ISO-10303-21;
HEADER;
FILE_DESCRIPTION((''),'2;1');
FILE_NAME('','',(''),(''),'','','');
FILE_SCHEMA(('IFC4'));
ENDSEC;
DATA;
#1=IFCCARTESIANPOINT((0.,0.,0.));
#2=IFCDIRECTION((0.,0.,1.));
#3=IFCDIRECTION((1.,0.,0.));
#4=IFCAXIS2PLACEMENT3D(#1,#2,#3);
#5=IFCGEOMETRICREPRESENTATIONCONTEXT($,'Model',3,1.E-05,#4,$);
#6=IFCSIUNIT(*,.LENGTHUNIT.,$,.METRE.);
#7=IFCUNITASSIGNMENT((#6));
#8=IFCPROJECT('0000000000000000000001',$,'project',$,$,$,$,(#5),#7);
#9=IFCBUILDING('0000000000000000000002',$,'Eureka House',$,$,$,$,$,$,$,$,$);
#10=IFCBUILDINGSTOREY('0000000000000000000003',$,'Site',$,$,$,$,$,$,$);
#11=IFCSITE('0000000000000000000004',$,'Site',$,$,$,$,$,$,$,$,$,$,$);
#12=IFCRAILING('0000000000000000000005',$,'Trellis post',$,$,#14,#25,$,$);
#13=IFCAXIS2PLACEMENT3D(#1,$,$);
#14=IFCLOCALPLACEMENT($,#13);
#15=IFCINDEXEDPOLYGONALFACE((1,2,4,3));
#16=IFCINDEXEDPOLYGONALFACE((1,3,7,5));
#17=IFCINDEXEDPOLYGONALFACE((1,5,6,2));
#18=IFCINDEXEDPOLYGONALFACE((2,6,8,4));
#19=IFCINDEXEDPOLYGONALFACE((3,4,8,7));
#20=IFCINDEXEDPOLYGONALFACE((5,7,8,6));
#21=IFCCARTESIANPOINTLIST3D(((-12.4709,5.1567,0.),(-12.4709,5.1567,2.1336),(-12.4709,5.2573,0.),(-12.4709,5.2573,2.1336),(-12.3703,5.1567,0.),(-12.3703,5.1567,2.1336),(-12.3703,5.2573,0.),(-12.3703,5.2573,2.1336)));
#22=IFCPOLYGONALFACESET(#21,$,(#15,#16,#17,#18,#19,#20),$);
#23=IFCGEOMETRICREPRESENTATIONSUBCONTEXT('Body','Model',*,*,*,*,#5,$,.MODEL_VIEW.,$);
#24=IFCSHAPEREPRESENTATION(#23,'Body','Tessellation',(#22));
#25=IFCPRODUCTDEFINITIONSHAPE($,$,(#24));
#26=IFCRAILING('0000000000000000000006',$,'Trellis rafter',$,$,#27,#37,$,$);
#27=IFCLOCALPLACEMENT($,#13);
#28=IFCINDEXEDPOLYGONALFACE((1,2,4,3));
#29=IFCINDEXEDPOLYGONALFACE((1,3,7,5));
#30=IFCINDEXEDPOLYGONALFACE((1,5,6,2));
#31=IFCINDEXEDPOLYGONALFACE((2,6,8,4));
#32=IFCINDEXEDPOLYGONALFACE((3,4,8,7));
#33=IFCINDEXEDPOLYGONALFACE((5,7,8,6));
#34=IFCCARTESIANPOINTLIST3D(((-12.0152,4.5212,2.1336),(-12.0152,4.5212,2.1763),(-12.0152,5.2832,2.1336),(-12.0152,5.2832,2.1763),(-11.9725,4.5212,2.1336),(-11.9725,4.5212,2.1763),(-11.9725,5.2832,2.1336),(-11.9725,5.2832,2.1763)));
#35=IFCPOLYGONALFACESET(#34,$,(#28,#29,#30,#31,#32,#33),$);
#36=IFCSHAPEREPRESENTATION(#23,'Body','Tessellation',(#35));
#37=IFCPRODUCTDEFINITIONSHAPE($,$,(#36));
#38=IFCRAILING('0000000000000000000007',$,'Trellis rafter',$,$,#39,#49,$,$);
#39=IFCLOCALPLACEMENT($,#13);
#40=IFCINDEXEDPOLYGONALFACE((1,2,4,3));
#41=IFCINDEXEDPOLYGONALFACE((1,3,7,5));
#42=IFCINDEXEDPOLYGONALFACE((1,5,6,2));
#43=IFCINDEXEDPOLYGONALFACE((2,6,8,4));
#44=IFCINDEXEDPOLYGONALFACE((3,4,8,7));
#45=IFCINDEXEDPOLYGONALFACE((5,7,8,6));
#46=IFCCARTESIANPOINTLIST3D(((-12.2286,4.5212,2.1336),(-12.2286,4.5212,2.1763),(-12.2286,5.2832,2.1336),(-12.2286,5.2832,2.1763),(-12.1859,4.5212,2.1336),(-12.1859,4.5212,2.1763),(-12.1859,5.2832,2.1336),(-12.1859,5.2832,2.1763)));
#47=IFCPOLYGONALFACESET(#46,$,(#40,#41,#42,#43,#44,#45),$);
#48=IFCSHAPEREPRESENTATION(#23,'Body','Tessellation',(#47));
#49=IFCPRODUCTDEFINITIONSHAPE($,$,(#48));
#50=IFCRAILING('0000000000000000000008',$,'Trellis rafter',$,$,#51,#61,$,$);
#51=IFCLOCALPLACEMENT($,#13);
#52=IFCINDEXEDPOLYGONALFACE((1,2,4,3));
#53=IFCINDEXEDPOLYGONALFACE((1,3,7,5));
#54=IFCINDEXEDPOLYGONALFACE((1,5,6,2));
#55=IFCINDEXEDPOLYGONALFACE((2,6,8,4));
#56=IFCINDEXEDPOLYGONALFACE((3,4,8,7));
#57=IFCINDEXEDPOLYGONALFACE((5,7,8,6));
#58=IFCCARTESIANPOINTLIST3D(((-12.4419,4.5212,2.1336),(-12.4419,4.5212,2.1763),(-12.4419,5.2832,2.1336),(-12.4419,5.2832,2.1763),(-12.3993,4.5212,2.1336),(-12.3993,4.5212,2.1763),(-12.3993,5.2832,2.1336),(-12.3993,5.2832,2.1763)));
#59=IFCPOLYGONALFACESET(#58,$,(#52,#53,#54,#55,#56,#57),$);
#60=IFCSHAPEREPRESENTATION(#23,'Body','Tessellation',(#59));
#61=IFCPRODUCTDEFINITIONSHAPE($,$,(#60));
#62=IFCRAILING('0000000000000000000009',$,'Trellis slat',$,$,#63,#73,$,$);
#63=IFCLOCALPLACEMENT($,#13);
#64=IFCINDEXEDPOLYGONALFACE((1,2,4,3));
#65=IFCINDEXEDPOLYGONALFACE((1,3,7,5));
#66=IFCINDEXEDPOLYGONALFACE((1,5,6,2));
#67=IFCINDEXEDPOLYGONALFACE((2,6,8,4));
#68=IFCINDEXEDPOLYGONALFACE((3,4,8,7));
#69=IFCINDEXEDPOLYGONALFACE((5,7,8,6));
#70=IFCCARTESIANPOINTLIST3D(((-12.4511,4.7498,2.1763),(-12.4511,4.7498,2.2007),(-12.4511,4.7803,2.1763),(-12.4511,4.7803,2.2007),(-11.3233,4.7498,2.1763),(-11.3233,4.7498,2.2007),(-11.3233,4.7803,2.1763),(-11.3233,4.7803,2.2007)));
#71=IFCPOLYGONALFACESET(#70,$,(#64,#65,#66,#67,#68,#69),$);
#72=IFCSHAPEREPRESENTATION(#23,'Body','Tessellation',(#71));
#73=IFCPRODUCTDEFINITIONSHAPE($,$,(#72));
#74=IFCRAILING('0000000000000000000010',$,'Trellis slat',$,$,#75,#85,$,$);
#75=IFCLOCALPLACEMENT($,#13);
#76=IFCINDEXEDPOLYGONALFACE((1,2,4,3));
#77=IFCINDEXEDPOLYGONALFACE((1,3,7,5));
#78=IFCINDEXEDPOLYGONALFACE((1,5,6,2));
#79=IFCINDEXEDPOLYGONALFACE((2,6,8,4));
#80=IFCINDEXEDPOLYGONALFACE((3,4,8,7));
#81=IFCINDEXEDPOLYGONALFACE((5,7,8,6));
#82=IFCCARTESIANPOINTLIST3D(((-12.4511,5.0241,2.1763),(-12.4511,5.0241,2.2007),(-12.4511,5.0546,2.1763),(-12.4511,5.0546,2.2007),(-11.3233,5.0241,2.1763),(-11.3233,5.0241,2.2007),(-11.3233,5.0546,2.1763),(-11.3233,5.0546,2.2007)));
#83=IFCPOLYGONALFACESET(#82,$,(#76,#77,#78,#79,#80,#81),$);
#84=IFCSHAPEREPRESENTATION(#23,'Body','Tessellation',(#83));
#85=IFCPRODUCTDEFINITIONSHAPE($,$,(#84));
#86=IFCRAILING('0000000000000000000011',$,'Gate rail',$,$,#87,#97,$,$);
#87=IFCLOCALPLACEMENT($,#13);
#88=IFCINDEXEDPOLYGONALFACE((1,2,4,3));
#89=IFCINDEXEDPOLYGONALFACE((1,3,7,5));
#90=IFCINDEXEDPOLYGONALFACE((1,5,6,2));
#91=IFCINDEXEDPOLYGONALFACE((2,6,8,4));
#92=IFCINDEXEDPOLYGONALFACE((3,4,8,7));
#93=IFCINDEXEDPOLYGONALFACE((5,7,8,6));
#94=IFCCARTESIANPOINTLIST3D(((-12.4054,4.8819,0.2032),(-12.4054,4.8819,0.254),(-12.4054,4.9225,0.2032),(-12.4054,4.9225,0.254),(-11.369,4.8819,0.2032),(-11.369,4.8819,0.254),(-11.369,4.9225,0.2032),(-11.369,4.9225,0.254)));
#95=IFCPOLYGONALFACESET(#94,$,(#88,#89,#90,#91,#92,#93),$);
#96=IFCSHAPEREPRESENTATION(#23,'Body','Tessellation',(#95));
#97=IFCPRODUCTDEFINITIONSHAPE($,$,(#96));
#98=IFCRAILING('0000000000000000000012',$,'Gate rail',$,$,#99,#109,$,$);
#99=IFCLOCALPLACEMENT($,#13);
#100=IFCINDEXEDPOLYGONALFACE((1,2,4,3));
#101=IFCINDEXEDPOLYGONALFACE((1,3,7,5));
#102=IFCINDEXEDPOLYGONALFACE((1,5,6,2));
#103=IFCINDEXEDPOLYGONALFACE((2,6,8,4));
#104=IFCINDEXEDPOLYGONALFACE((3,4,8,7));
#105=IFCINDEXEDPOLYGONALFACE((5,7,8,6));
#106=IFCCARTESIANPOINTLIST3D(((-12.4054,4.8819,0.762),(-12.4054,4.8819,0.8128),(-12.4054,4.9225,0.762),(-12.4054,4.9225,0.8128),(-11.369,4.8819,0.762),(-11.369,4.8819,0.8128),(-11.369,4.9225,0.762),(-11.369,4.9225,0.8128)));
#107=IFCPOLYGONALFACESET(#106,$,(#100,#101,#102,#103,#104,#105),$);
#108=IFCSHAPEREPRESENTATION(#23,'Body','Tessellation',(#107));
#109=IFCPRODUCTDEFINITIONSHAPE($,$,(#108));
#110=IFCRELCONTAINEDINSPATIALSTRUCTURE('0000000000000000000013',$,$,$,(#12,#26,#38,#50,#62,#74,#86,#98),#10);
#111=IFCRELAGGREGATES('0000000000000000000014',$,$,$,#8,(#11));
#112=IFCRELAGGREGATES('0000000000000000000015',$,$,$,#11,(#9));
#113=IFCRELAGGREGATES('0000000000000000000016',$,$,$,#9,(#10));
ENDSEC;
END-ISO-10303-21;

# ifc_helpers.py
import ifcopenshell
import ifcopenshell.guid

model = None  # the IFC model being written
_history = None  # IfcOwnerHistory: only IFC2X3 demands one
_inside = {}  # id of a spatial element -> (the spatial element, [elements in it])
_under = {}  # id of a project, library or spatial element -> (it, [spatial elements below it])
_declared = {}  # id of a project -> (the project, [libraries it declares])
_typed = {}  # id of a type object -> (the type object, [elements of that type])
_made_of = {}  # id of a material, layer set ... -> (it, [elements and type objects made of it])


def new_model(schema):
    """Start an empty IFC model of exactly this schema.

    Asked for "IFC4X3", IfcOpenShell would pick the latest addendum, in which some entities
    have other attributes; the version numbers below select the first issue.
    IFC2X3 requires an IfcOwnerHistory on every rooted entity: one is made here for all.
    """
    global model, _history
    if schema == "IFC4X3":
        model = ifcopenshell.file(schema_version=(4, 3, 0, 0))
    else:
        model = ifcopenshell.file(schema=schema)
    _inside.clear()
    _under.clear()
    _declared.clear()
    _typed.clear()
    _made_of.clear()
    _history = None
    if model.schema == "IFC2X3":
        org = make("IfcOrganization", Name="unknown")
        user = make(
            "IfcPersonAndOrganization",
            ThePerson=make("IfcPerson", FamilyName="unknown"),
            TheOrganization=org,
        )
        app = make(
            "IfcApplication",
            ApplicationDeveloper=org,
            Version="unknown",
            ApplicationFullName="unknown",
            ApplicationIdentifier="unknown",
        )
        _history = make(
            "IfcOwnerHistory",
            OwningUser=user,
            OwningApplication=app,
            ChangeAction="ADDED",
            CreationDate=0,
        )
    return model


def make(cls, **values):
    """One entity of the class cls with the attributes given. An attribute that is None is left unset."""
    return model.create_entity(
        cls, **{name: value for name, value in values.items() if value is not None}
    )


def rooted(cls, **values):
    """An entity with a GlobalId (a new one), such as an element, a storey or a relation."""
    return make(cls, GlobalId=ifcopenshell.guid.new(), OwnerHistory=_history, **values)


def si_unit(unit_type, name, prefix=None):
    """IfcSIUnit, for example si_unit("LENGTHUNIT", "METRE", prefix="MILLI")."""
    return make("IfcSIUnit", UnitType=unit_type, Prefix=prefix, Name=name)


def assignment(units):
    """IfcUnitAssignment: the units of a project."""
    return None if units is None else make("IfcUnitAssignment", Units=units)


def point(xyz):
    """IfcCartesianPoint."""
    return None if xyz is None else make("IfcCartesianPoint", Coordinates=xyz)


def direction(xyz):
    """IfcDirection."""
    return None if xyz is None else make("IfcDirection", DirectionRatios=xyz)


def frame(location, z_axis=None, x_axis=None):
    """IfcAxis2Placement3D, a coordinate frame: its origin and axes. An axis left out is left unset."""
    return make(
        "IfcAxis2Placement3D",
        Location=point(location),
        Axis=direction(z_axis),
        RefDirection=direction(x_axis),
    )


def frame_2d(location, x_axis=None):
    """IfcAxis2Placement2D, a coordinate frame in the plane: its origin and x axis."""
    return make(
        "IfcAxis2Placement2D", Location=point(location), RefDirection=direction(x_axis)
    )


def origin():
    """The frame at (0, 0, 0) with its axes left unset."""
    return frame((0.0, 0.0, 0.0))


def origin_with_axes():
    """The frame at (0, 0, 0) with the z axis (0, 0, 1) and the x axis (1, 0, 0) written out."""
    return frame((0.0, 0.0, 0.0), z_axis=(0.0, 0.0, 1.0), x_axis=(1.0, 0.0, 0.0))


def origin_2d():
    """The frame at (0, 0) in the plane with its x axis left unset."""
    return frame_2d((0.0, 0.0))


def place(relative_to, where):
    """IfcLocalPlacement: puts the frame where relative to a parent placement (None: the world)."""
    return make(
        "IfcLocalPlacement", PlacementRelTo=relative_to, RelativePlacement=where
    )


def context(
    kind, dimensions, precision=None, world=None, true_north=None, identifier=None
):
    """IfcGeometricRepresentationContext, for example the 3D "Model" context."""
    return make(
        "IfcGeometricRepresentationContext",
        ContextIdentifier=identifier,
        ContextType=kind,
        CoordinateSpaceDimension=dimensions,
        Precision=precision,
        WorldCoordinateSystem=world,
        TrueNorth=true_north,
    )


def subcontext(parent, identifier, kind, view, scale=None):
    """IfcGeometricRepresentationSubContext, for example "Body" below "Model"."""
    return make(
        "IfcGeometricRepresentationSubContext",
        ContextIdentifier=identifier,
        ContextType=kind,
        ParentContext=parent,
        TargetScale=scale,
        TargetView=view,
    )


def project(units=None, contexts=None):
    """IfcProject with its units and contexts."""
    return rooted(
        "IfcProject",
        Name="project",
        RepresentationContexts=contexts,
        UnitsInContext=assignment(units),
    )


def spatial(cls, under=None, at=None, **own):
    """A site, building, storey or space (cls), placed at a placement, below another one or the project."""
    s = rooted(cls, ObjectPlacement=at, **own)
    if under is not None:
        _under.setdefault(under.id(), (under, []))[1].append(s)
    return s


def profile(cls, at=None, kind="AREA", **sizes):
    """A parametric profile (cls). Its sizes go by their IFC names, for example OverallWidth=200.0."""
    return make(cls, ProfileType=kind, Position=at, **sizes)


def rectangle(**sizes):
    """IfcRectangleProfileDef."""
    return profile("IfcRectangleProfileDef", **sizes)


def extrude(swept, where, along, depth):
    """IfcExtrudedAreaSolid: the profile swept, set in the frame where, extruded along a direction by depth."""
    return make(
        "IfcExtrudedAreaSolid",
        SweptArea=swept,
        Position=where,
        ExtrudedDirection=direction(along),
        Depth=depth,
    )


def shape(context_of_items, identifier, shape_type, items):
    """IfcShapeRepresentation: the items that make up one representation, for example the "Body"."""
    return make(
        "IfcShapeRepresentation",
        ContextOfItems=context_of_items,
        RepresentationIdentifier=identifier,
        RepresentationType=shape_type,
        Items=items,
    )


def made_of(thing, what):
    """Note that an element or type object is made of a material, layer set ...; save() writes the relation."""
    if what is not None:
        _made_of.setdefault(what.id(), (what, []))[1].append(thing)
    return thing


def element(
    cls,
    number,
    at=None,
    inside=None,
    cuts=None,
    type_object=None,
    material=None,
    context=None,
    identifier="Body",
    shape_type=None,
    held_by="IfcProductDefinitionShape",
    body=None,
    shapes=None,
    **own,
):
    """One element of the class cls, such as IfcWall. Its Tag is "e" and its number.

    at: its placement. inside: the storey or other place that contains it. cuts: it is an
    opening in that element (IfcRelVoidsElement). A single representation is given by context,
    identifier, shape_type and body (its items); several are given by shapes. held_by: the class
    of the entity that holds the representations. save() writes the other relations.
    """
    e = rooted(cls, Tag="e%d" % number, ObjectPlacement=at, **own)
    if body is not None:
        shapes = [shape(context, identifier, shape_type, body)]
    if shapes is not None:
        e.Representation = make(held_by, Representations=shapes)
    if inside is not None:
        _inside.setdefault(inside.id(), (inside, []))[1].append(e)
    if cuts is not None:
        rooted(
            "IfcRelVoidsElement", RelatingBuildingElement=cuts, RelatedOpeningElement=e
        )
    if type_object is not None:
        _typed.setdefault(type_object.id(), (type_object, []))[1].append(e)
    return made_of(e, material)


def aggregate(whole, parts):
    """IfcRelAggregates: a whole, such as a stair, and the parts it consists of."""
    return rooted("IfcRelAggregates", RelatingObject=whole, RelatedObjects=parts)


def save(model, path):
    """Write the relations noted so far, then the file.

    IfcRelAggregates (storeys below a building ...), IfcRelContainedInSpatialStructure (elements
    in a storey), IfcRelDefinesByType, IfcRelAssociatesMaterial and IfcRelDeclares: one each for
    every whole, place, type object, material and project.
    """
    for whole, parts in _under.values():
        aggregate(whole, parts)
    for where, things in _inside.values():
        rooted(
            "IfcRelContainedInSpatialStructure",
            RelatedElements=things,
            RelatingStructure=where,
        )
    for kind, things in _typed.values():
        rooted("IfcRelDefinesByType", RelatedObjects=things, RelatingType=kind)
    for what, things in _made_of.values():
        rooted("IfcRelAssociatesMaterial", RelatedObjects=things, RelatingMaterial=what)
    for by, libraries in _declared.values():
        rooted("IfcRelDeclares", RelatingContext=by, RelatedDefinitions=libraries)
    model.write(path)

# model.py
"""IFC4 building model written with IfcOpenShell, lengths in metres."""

from ifc_helpers import new_model, si_unit, frame, origin, origin_with_axes, origin_2d, place, context, subcontext, project, spatial, rectangle, extrude, element, save


model = new_model("IFC4")

# Units and contexts
model_context = context("Model", 3, precision=1e-05, world=origin_with_axes())
body_context = subcontext(model_context, "Body", "Model", "MODEL_VIEW")
ifc_project = project(units=[si_unit("LENGTHUNIT", "METRE")], contexts=[model_context])

# Site, building, storey
site = spatial("IfcSite", under=ifc_project, Name="Site")
building = spatial("IfcBuilding", under=site, Name="Eureka House")
storey = spatial("IfcBuildingStorey", under=building, Name="Site")

# Railings
railing_1_placement = place(None, frame((-12.4206, 5.207, 0.0), z_axis=(0.0, 0.0, 1.0), x_axis=(1.0, 0.0, 0.0)))
element("IfcRailing", 1, at=railing_1_placement, inside=storey, Name="Trellis post", context=body_context, shape_type="SweptSolid", body=[
    extrude(rectangle(XDim=0.1006, YDim=0.1006, at=origin_2d()), origin(), (0.0, 0.0, 1.0), 2.1336),
])
for number, where, z_axis, x_axis, name in (
    (2, (-11.9939, 4.9022, 2.1336), (0.0, 0.0, 1.0), (1.0, 0.0, 0.0), "Trellis rafter"),
    (3, (-12.2072, 4.9022, 2.1336), (0.0, 0.0, 1.0), (1.0, 0.0, 0.0), "Trellis rafter"),
    (4, (-12.4206, 4.9022, 2.1336), (0.0, 0.0, 1.0), (1.0, 0.0, 0.0), "Trellis rafter"),
):
    element("IfcRailing", number, at=place(None, frame(where, z_axis=z_axis, x_axis=x_axis)), inside=storey, Name=name, context=body_context, shape_type="SweptSolid", body=[
        extrude(rectangle(XDim=0.0427, YDim=0.762, at=origin_2d()), origin(), (0.0, 0.0, 1.0), 0.0427),
    ])
for number, where, z_axis, x_axis, name in (
    (5, (-11.8872, 4.765, 2.1763), (0.0, 0.0, 1.0), (1.0, 0.0, 0.0), "Trellis slat"),
    (6, (-11.8872, 5.0393, 2.1763), (0.0, 0.0, 1.0), (1.0, 0.0, 0.0), "Trellis slat"),
):
    element("IfcRailing", number, at=place(None, frame(where, z_axis=z_axis, x_axis=x_axis)), inside=storey, Name=name, context=body_context, shape_type="SweptSolid", body=[
        extrude(rectangle(XDim=1.1278, YDim=0.0305, at=origin_2d()), origin(), (0.0, 0.0, 1.0), 0.0244),
    ])
for number, where, z_axis, x_axis, name in (
    (7, (-11.8872, 4.9022, 0.2032), (0.0, 0.0, 1.0), (1.0, 0.0, 0.0), "Gate rail"),
    (8, (-11.8872, 4.9022, 0.762), (0.0, 0.0, 1.0), (1.0, 0.0, 0.0), "Gate rail"),
):
    element("IfcRailing", number, at=place(None, frame(where, z_axis=z_axis, x_axis=x_axis)), inside=storey, Name=name, context=body_context, shape_type="SweptSolid", body=[
        extrude(rectangle(XDim=1.0363, YDim=0.0406, at=origin_2d()), origin(), (0.0, 0.0, 1.0), 0.0508),
    ])

save(model, "model.ifc")
